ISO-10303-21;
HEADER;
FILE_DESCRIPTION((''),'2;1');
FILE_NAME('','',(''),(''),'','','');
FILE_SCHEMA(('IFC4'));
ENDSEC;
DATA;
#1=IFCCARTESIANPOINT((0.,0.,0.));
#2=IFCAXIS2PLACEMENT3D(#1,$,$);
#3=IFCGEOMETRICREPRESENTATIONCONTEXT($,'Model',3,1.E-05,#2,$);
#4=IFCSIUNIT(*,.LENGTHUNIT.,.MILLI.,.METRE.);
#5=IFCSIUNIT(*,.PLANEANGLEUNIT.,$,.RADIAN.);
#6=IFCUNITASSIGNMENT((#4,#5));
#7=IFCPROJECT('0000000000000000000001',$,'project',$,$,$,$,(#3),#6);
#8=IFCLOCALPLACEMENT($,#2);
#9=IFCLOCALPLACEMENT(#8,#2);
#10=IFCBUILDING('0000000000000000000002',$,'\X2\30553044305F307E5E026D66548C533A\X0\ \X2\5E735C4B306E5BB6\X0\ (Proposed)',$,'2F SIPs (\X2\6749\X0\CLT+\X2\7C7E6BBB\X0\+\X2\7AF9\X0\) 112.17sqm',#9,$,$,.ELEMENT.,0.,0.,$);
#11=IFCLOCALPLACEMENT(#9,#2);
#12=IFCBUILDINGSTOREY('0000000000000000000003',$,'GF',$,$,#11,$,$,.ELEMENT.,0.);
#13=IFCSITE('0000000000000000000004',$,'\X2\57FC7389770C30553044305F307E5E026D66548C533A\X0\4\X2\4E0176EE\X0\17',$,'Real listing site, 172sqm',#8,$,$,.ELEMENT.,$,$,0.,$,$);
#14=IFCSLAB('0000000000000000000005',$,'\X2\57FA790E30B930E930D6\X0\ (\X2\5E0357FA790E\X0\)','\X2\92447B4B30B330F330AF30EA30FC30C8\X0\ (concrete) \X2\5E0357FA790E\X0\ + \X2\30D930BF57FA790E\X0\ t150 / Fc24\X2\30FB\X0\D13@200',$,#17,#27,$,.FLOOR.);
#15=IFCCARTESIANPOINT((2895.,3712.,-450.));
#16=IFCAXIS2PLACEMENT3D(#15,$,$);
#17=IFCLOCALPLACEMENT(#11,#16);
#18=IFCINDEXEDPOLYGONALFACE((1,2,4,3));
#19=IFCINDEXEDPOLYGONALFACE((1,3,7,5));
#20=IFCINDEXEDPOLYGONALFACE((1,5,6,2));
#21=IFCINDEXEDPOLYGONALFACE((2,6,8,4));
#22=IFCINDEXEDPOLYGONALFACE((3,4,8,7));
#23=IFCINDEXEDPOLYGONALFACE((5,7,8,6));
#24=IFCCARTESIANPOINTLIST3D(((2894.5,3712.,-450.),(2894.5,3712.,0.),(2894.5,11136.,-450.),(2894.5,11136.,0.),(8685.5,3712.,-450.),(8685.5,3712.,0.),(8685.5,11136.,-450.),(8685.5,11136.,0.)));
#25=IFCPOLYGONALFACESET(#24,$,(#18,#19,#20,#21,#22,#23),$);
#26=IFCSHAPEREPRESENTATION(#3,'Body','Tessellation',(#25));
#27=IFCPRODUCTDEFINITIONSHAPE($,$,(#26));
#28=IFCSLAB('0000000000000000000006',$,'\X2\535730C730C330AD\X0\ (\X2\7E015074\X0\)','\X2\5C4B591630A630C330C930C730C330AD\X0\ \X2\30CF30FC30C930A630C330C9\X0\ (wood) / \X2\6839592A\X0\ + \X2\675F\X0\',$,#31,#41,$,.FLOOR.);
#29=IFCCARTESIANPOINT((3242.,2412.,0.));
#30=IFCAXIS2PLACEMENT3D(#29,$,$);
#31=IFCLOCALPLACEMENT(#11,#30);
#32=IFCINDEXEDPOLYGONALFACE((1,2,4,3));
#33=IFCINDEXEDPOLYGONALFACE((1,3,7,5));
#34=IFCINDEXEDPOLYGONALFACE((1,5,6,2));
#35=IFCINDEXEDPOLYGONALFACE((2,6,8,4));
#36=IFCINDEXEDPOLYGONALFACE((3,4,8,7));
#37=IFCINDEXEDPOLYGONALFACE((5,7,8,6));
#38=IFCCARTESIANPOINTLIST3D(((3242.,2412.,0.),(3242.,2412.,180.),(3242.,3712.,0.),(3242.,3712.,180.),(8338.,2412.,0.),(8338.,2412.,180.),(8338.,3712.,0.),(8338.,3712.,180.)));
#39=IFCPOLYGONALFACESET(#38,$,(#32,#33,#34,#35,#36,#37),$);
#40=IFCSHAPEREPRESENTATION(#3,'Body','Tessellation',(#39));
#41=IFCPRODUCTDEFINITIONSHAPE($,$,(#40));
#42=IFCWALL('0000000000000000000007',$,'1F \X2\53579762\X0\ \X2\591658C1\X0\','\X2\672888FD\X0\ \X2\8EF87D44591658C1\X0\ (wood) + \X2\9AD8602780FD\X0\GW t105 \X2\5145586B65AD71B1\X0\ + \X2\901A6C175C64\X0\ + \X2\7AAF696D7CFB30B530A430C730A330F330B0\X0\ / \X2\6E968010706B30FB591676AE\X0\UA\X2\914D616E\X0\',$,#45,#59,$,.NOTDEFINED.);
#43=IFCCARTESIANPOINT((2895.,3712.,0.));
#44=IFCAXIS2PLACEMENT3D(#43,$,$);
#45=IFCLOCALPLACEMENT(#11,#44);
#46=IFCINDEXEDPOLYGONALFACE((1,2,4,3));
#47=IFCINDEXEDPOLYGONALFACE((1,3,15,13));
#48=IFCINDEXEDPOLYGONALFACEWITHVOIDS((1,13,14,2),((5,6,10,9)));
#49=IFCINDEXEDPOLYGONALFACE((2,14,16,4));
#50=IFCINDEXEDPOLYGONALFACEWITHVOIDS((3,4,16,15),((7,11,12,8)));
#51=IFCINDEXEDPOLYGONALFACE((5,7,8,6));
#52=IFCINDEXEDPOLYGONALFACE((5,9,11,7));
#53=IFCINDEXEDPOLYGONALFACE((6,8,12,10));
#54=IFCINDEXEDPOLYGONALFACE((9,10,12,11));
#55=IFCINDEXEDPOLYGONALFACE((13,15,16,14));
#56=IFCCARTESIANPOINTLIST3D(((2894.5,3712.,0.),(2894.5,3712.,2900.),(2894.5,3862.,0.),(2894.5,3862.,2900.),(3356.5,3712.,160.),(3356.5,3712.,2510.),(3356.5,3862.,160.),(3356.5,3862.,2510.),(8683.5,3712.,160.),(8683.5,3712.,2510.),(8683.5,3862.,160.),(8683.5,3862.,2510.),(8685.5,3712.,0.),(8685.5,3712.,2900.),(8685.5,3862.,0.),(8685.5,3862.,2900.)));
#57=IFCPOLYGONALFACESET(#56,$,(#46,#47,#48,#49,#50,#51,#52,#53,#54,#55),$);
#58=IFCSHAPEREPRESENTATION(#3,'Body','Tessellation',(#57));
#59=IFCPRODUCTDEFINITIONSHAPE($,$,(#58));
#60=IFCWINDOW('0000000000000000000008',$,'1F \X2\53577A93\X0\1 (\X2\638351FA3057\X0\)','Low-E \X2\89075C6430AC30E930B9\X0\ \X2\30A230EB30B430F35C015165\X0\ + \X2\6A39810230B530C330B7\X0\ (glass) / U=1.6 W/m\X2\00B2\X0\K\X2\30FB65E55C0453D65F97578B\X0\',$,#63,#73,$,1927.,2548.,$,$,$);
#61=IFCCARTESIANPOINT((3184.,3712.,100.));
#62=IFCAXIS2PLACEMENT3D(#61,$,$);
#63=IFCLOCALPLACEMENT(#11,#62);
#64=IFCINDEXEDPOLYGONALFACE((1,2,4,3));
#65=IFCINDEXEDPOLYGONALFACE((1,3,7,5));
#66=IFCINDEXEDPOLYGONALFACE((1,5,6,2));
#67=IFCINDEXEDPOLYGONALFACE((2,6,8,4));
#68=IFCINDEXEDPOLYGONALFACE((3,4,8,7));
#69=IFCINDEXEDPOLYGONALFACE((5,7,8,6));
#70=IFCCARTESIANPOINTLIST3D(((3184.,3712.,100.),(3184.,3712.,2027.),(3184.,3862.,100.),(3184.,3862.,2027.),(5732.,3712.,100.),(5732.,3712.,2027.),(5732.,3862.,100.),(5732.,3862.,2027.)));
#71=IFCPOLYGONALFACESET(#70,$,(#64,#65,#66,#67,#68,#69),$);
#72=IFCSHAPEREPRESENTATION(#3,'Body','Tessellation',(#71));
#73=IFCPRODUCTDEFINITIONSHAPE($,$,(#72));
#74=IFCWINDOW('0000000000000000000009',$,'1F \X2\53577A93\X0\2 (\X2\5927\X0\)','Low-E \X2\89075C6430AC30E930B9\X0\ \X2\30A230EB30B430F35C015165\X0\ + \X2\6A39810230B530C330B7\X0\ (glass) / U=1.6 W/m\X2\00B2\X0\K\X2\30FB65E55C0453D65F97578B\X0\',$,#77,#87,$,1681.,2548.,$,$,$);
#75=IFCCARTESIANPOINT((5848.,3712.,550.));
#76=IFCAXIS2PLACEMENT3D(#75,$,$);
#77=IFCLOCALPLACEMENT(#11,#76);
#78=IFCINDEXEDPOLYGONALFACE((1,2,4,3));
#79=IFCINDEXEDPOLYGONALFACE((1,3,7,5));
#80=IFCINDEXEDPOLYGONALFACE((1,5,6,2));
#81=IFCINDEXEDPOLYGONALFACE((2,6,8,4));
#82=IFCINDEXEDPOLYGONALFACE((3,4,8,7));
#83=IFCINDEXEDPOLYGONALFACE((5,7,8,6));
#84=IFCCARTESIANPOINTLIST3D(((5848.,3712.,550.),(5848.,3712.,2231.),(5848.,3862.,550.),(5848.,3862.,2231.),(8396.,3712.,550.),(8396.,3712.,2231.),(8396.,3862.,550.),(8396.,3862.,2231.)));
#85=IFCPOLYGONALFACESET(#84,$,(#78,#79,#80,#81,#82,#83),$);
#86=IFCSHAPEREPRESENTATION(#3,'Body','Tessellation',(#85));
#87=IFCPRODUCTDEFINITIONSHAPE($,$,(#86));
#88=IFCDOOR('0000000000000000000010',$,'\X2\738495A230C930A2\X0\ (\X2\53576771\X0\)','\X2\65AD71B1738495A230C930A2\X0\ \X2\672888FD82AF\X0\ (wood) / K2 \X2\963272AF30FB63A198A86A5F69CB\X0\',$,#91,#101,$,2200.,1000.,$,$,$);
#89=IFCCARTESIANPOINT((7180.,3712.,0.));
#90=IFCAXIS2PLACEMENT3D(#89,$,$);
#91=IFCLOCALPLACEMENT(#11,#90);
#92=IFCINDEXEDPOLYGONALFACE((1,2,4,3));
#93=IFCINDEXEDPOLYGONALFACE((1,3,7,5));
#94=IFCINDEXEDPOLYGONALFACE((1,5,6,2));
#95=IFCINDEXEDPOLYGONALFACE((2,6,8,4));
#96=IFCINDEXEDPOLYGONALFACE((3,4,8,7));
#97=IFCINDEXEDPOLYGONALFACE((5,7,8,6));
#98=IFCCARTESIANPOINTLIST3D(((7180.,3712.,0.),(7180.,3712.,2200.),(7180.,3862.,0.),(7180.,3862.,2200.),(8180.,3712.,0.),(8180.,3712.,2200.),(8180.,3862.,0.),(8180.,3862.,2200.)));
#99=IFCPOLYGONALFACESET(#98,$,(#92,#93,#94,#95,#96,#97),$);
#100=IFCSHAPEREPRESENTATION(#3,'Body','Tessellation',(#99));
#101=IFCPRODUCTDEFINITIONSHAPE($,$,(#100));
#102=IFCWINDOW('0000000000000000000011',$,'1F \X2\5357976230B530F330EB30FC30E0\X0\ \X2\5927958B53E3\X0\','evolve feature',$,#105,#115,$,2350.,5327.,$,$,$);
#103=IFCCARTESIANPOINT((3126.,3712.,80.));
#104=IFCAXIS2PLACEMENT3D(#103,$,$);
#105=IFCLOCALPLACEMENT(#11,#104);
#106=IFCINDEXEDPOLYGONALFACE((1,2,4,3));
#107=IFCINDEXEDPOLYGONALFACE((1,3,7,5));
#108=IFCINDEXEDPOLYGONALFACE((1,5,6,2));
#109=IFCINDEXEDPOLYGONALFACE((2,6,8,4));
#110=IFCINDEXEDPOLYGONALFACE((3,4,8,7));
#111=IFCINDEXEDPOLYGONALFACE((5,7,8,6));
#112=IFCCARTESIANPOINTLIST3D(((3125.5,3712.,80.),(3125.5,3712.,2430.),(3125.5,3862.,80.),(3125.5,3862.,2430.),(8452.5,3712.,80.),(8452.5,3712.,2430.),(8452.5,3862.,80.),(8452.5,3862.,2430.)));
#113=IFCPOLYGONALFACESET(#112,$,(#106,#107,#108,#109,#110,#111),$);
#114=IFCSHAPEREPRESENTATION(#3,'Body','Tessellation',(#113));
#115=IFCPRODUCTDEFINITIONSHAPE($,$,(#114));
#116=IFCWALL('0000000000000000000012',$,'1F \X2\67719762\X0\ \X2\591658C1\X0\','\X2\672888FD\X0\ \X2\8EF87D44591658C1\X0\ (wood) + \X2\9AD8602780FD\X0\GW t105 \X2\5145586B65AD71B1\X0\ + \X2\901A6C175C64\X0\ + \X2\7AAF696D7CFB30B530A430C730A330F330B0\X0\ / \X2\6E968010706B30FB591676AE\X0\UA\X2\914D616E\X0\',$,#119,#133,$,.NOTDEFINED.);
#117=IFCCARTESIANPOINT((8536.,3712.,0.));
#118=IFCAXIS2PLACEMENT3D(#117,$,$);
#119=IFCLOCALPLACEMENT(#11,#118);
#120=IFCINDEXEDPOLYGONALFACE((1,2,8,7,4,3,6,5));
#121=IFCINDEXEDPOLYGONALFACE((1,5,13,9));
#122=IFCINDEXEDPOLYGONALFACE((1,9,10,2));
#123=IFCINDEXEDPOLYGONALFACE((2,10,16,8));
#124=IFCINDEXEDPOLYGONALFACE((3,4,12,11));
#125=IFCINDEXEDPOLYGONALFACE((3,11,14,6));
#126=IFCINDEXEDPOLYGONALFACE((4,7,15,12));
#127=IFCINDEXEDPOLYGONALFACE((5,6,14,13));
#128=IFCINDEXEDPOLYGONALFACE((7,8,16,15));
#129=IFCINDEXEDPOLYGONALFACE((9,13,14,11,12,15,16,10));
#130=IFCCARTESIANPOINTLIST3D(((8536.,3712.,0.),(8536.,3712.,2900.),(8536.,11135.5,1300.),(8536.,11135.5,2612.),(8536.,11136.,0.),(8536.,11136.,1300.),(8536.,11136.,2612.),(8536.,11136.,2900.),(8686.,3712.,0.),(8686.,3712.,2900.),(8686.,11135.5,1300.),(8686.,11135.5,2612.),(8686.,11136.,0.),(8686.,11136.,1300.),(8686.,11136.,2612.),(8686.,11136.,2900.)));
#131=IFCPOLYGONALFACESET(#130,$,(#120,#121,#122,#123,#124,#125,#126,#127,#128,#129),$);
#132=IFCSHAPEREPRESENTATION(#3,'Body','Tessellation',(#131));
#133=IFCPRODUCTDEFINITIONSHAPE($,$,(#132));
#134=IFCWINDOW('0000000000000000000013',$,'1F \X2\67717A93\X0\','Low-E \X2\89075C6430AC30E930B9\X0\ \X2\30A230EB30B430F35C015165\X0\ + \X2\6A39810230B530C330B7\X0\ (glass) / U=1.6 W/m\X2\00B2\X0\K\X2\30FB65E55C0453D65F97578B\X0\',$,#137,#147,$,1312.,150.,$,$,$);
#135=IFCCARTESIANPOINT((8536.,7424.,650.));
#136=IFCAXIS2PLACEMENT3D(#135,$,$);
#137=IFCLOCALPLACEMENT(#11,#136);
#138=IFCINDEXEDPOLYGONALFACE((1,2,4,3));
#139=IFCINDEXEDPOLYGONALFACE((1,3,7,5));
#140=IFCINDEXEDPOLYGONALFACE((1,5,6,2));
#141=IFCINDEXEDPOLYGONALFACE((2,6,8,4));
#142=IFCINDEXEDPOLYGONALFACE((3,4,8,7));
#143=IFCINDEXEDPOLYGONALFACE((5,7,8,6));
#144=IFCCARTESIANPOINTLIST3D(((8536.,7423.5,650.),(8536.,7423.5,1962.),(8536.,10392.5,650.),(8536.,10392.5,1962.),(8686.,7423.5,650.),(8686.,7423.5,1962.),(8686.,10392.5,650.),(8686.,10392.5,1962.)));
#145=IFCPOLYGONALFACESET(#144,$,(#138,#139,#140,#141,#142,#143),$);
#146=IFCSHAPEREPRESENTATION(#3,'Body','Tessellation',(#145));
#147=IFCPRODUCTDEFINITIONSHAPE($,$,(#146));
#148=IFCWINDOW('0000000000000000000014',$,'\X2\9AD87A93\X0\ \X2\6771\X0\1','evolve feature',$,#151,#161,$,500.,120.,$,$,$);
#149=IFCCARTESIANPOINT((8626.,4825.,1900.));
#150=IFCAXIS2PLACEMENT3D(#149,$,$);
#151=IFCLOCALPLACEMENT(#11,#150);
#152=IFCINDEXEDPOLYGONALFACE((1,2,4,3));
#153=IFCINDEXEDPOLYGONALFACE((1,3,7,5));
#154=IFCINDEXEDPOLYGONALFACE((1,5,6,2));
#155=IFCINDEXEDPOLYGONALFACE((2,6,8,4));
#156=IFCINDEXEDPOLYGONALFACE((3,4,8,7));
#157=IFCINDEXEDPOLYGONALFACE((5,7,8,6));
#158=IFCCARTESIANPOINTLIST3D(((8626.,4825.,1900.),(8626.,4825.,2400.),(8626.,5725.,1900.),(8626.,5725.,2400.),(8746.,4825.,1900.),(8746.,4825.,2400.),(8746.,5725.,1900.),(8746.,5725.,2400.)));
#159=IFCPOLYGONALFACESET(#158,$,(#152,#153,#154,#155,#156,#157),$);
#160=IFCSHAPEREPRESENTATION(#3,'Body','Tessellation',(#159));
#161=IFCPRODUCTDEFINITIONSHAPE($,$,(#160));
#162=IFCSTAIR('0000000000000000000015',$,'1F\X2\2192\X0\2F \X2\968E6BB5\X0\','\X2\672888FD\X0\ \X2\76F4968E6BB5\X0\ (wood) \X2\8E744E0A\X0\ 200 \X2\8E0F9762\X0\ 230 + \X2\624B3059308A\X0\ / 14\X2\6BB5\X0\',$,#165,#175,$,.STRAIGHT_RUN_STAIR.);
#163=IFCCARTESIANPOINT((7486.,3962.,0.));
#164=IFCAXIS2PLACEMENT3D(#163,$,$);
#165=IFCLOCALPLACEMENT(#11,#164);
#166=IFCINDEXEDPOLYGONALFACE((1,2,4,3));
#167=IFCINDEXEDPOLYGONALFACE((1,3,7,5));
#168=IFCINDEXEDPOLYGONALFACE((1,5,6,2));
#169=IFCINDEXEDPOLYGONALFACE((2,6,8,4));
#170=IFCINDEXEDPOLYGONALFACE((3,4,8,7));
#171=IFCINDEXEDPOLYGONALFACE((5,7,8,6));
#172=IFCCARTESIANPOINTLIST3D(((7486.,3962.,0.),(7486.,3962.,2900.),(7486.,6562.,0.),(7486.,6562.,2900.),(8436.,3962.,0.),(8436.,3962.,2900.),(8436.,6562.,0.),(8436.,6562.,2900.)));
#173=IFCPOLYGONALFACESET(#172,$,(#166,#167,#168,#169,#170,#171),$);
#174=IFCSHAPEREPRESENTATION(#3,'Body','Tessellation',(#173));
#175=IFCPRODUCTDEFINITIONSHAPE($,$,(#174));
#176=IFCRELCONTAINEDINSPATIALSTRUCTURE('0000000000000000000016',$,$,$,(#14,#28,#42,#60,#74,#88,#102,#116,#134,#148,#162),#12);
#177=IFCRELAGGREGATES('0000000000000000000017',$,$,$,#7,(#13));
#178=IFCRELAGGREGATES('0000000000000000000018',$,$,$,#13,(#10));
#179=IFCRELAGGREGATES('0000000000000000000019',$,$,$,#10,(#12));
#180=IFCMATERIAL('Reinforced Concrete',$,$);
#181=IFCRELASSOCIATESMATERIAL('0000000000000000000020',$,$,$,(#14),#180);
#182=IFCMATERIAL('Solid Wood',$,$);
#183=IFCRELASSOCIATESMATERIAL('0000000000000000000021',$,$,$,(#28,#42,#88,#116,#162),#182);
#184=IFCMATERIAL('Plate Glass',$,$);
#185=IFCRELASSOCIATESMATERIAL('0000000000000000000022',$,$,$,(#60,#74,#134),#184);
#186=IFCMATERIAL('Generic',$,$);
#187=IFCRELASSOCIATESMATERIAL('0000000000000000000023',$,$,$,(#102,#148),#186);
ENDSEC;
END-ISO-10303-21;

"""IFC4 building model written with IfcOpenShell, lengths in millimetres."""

from ifc_helpers import new_model, si_unit, frame, frame_2d, origin, place, context, project, spatial, rectangle, extrude, material, element, fill, save


model = new_model("IFC4")

# Units and contexts
model_context = context("Model", 3, precision=1e-05, world=origin())
ifc_project = project(units=[si_unit("LENGTHUNIT", "METRE", prefix="MILLI"), si_unit("PLANEANGLEUNIT", "RADIAN")], contexts=[model_context])

# Site, building, storey
site_placement = place(None, origin())
site = spatial("IfcSite", under=ifc_project, at=site_placement, Name="埼玉県さいたま市浦和区4丁目17", ObjectType="Real listing site, 172sqm", CompositionType="ELEMENT", RefElevation=0.0)
building_placement = place(site_placement, origin())
building = spatial("IfcBuilding", under=site, at=building_placement, Name="さいたま市浦和区 平屋の家 (Proposed)", ObjectType="2F SIPs (杉CLT+籾殻+竹) 112.17sqm", CompositionType="ELEMENT", ElevationOfRefHeight=0.0, ElevationOfTerrain=0.0)
storey_placement = place(building_placement, origin())
storey = spatial("IfcBuildingStorey", under=building, at=storey_placement, Name="GF", CompositionType="ELEMENT", Elevation=0.0)

# Slabs
ifc_material_1 = material(Name="Reinforced Concrete")
slab_1_placement = place(storey_placement, frame((2895.0, 3712.0, -450.0)))
element("IfcSlab", 1, at=slab_1_placement, inside=storey, material=ifc_material_1, Name="基礎スラブ (布基礎)", Description="鉄筋コンクリート (concrete) 布基礎 + ベタ基礎 t150 / Fc24・D13@200", PredefinedType="FLOOR", context=model_context, shape_type="SweptSolid", body=[
    extrude(rectangle(XDim=5791.0, YDim=7424.0, at=frame_2d((2895.0, 3712.0))), frame((2895.0, 3712.0, -450.0)), (0.0, 0.0, 1.0), 450.0),
])
ifc_material_2 = material(Name="Solid Wood")
slab_2_placement = place(storey_placement, frame((3242.0, 2412.0, 0.0)))
element("IfcSlab", 2, at=slab_2_placement, inside=storey, material=ifc_material_2, Name="南デッキ (縁側)", Description="屋外ウッドデッキ ハードウッド (wood) / 根太 + 束", PredefinedType="FLOOR", context=model_context, shape_type="SweptSolid", body=[
    extrude(rectangle(XDim=5096.0, YDim=1300.0, at=frame_2d((2548.0, 650.0))), frame((3242.0, 2412.0, 0.0)), (0.0, 0.0, 1.0), 180.0),
])
ifc_material_3 = material(Name="Generic")

# Wall, openings, windows, door
wall_1_placement = place(storey_placement, frame((2895.0, 3712.0, 0.0)))
wall_1 = element("IfcWall", 3, at=wall_1_placement, inside=storey, material=ifc_material_2, Name="1F 南面 外壁", Description="木製 軸組外壁 (wood) + 高性能GW t105 充填断熱 + 通気層 + 窯業系サイディング / 準耐火・外皮UA配慮", PredefinedType="NOTDEFINED", context=model_context, shape_type="SweptSolid", body=[
    extrude(rectangle(XDim=5791.0, YDim=150.0, at=frame_2d((2895.0, 75.0))), frame((2895.0, 3712.0, 0.0)), (0.0, 0.0, 1.0), 2900.0),
])
opening_1_placement = place(storey_placement, frame((3184.0, 3712.0, 100.0)))
opening_1 = element("IfcOpeningElement", 4, at=opening_1_placement, cuts=wall_1, PredefinedType="NOTDEFINED", context=model_context, shape_type="SweptSolid", body=[
    extrude(rectangle(XDim=2548.0, YDim=150.0, at=frame_2d((1274.0, 75.0))), frame((3184.0, 3712.0, 100.0)), (0.0, 0.0, 1.0), 1927.0),
])
opening_2_placement = place(storey_placement, frame((5848.0, 3712.0, 550.0)))
opening_2 = element("IfcOpeningElement", 5, at=opening_2_placement, cuts=wall_1, PredefinedType="NOTDEFINED", context=model_context, shape_type="SweptSolid", body=[
    extrude(rectangle(XDim=2548.0, YDim=150.0, at=frame_2d((1274.0, 75.0))), frame((5848.0, 3712.0, 550.0)), (0.0, 0.0, 1.0), 1681.0),
])
opening_3_placement = place(storey_placement, frame((7180.0, 3712.0, 0.0)))
opening_3 = element("IfcOpeningElement", 6, at=opening_3_placement, cuts=wall_1, PredefinedType="NOTDEFINED", context=model_context, shape_type="SweptSolid", body=[
    extrude(rectangle(XDim=1000.0, YDim=150.0, at=frame_2d((500.0, 75.0))), frame((7180.0, 3712.0, 0.0)), (0.0, 0.0, 1.0), 2200.0),
])
opening_4_placement = place(storey_placement, frame((3126.0, 3712.0, 80.0)))
opening_4 = element("IfcOpeningElement", 7, at=opening_4_placement, cuts=wall_1, PredefinedType="NOTDEFINED", context=model_context, shape_type="SweptSolid", body=[
    extrude(rectangle(XDim=5327.0, YDim=150.0, at=frame_2d((2663.0, 75.0))), frame((3126.0, 3712.0, 80.0)), (0.0, 0.0, 1.0), 2350.0),
])
ifc_material_4 = material(Name="Plate Glass")
window_1_placement = place(storey_placement, frame((3184.0, 3712.0, 100.0)))
window_1 = element("IfcWindow", 8, at=window_1_placement, inside=storey, material=ifc_material_4, Name="1F 南窓1 (掃出し)", Description="Low-E 複層ガラス アルゴン封入 + 樹脂サッシ (glass) / U=1.6 W/m²K・日射取得型", OverallHeight=1927.0, OverallWidth=2548.0, context=model_context, shape_type="SweptSolid", body=[
    extrude(rectangle(XDim=2548.0, YDim=150.0, at=frame_2d((1274.0, 75.0))), frame((3184.0, 3712.0, 100.0)), (0.0, 0.0, 1.0), 1927.0),
])
fill(opening_1, window_1)
window_2_placement = place(storey_placement, frame((5848.0, 3712.0, 550.0)))
window_2 = element("IfcWindow", 9, at=window_2_placement, inside=storey, material=ifc_material_4, Name="1F 南窓2 (大)", Description="Low-E 複層ガラス アルゴン封入 + 樹脂サッシ (glass) / U=1.6 W/m²K・日射取得型", OverallHeight=1681.0, OverallWidth=2548.0, context=model_context, shape_type="SweptSolid", body=[
    extrude(rectangle(XDim=2548.0, YDim=150.0, at=frame_2d((1274.0, 75.0))), frame((5848.0, 3712.0, 550.0)), (0.0, 0.0, 1.0), 1681.0),
])
fill(opening_2, window_2)
door_placement = place(storey_placement, frame((7180.0, 3712.0, 0.0)))
door = element("IfcDoor", 10, at=door_placement, inside=storey, material=ifc_material_2, Name="玄関ドア (南東)", Description="断熱玄関ドア 木製芯 (wood) / K2 防犯・採風機構", OverallHeight=2200.0, OverallWidth=1000.0, context=model_context, shape_type="SweptSolid", body=[
    extrude(rectangle(XDim=1000.0, YDim=150.0, at=frame_2d((500.0, 75.0))), frame((7180.0, 3712.0, 0.0)), (0.0, 0.0, 1.0), 2200.0),
])
fill(opening_3, door)
window_3_placement = place(storey_placement, frame((3126.0, 3712.0, 80.0)))
window_3 = element("IfcWindow", 11, at=window_3_placement, inside=storey, material=ifc_material_3, Name="1F 南面サンルーム 大開口", Description="evolve feature", OverallHeight=2350.0, OverallWidth=5327.0, context=model_context, shape_type="SweptSolid", body=[
    extrude(rectangle(XDim=5327.0, YDim=150.0, at=frame_2d((2663.0, 75.0))), frame((3126.0, 3712.0, 80.0)), (0.0, 0.0, 1.0), 2350.0),
])
fill(opening_4, window_3)

# Wall, openings, windows
wall_2_placement = place(storey_placement, frame((8536.0, 3712.0, 0.0)))
wall_2 = element("IfcWall", 12, at=wall_2_placement, inside=storey, material=ifc_material_2, Name="1F 東面 外壁", Description="木製 軸組外壁 (wood) + 高性能GW t105 充填断熱 + 通気層 + 窯業系サイディング / 準耐火・外皮UA配慮", PredefinedType="NOTDEFINED", context=model_context, shape_type="SweptSolid", body=[
    extrude(rectangle(XDim=150.0, YDim=7424.0, at=frame_2d((75.0, 3712.0))), frame((8536.0, 3712.0, 0.0)), (0.0, 0.0, 1.0), 2900.0),
])
opening_5_placement = place(storey_placement, frame((8536.0, 7424.0, 650.0)))
opening_5 = element("IfcOpeningElement", 13, at=opening_5_placement, cuts=wall_2, PredefinedType="NOTDEFINED", context=model_context, shape_type="SweptSolid", body=[
    extrude(rectangle(XDim=150.0, YDim=2969.0, at=frame_2d((75.0, 1484.0))), frame((8536.0, 7424.0, 650.0)), (0.0, 0.0, 1.0), 1312.0),
])
opening_6_placement = place(storey_placement, frame((8626.0, 4825.0, 1900.0)))
opening_6 = element("IfcOpeningElement", 14, at=opening_6_placement, cuts=wall_2, PredefinedType="NOTDEFINED", context=model_context, shape_type="SweptSolid", body=[
    extrude(rectangle(XDim=120.0, YDim=900.0, at=frame_2d((60.0, 450.0))), frame((8626.0, 4825.0, 1900.0)), (0.0, 0.0, 1.0), 500.0),
])
window_4_placement = place(storey_placement, frame((8536.0, 7424.0, 650.0)))
window_4 = element("IfcWindow", 15, at=window_4_placement, inside=storey, material=ifc_material_4, Name="1F 東窓", Description="Low-E 複層ガラス アルゴン封入 + 樹脂サッシ (glass) / U=1.6 W/m²K・日射取得型", OverallHeight=1312.0, OverallWidth=150.0, context=model_context, shape_type="SweptSolid", body=[
    extrude(rectangle(XDim=150.0, YDim=2969.0, at=frame_2d((75.0, 1484.0))), frame((8536.0, 7424.0, 650.0)), (0.0, 0.0, 1.0), 1312.0),
])
fill(opening_5, window_4)
window_5_placement = place(storey_placement, frame((8626.0, 4825.0, 1900.0)))
window_5 = element("IfcWindow", 16, at=window_5_placement, inside=storey, material=ifc_material_3, Name="高窓 東1", Description="evolve feature", OverallHeight=500.0, OverallWidth=120.0, context=model_context, shape_type="SweptSolid", body=[
    extrude(rectangle(XDim=120.0, YDim=900.0, at=frame_2d((60.0, 450.0))), frame((8626.0, 4825.0, 1900.0)), (0.0, 0.0, 1.0), 500.0),
])
fill(opening_6, window_5)

# Stair
stair_placement = place(storey_placement, frame((7486.0, 3962.0, 0.0)))
element("IfcStair", 17, at=stair_placement, inside=storey, material=ifc_material_2, Name="1F→2F 階段", Description="木製 直階段 (wood) 蹴上 200 踏面 230 + 手すり / 14段", PredefinedType="STRAIGHT_RUN_STAIR", context=model_context, shape_type="SweptSolid", body=[
    extrude(rectangle(XDim=950.0, YDim=2600.0, at=frame_2d((475.0, 1300.0))), frame((7486.0, 3962.0, 0.0)), (0.0, 0.0, 1.0), 2900.0),
])

save(model, "model.ifc")
